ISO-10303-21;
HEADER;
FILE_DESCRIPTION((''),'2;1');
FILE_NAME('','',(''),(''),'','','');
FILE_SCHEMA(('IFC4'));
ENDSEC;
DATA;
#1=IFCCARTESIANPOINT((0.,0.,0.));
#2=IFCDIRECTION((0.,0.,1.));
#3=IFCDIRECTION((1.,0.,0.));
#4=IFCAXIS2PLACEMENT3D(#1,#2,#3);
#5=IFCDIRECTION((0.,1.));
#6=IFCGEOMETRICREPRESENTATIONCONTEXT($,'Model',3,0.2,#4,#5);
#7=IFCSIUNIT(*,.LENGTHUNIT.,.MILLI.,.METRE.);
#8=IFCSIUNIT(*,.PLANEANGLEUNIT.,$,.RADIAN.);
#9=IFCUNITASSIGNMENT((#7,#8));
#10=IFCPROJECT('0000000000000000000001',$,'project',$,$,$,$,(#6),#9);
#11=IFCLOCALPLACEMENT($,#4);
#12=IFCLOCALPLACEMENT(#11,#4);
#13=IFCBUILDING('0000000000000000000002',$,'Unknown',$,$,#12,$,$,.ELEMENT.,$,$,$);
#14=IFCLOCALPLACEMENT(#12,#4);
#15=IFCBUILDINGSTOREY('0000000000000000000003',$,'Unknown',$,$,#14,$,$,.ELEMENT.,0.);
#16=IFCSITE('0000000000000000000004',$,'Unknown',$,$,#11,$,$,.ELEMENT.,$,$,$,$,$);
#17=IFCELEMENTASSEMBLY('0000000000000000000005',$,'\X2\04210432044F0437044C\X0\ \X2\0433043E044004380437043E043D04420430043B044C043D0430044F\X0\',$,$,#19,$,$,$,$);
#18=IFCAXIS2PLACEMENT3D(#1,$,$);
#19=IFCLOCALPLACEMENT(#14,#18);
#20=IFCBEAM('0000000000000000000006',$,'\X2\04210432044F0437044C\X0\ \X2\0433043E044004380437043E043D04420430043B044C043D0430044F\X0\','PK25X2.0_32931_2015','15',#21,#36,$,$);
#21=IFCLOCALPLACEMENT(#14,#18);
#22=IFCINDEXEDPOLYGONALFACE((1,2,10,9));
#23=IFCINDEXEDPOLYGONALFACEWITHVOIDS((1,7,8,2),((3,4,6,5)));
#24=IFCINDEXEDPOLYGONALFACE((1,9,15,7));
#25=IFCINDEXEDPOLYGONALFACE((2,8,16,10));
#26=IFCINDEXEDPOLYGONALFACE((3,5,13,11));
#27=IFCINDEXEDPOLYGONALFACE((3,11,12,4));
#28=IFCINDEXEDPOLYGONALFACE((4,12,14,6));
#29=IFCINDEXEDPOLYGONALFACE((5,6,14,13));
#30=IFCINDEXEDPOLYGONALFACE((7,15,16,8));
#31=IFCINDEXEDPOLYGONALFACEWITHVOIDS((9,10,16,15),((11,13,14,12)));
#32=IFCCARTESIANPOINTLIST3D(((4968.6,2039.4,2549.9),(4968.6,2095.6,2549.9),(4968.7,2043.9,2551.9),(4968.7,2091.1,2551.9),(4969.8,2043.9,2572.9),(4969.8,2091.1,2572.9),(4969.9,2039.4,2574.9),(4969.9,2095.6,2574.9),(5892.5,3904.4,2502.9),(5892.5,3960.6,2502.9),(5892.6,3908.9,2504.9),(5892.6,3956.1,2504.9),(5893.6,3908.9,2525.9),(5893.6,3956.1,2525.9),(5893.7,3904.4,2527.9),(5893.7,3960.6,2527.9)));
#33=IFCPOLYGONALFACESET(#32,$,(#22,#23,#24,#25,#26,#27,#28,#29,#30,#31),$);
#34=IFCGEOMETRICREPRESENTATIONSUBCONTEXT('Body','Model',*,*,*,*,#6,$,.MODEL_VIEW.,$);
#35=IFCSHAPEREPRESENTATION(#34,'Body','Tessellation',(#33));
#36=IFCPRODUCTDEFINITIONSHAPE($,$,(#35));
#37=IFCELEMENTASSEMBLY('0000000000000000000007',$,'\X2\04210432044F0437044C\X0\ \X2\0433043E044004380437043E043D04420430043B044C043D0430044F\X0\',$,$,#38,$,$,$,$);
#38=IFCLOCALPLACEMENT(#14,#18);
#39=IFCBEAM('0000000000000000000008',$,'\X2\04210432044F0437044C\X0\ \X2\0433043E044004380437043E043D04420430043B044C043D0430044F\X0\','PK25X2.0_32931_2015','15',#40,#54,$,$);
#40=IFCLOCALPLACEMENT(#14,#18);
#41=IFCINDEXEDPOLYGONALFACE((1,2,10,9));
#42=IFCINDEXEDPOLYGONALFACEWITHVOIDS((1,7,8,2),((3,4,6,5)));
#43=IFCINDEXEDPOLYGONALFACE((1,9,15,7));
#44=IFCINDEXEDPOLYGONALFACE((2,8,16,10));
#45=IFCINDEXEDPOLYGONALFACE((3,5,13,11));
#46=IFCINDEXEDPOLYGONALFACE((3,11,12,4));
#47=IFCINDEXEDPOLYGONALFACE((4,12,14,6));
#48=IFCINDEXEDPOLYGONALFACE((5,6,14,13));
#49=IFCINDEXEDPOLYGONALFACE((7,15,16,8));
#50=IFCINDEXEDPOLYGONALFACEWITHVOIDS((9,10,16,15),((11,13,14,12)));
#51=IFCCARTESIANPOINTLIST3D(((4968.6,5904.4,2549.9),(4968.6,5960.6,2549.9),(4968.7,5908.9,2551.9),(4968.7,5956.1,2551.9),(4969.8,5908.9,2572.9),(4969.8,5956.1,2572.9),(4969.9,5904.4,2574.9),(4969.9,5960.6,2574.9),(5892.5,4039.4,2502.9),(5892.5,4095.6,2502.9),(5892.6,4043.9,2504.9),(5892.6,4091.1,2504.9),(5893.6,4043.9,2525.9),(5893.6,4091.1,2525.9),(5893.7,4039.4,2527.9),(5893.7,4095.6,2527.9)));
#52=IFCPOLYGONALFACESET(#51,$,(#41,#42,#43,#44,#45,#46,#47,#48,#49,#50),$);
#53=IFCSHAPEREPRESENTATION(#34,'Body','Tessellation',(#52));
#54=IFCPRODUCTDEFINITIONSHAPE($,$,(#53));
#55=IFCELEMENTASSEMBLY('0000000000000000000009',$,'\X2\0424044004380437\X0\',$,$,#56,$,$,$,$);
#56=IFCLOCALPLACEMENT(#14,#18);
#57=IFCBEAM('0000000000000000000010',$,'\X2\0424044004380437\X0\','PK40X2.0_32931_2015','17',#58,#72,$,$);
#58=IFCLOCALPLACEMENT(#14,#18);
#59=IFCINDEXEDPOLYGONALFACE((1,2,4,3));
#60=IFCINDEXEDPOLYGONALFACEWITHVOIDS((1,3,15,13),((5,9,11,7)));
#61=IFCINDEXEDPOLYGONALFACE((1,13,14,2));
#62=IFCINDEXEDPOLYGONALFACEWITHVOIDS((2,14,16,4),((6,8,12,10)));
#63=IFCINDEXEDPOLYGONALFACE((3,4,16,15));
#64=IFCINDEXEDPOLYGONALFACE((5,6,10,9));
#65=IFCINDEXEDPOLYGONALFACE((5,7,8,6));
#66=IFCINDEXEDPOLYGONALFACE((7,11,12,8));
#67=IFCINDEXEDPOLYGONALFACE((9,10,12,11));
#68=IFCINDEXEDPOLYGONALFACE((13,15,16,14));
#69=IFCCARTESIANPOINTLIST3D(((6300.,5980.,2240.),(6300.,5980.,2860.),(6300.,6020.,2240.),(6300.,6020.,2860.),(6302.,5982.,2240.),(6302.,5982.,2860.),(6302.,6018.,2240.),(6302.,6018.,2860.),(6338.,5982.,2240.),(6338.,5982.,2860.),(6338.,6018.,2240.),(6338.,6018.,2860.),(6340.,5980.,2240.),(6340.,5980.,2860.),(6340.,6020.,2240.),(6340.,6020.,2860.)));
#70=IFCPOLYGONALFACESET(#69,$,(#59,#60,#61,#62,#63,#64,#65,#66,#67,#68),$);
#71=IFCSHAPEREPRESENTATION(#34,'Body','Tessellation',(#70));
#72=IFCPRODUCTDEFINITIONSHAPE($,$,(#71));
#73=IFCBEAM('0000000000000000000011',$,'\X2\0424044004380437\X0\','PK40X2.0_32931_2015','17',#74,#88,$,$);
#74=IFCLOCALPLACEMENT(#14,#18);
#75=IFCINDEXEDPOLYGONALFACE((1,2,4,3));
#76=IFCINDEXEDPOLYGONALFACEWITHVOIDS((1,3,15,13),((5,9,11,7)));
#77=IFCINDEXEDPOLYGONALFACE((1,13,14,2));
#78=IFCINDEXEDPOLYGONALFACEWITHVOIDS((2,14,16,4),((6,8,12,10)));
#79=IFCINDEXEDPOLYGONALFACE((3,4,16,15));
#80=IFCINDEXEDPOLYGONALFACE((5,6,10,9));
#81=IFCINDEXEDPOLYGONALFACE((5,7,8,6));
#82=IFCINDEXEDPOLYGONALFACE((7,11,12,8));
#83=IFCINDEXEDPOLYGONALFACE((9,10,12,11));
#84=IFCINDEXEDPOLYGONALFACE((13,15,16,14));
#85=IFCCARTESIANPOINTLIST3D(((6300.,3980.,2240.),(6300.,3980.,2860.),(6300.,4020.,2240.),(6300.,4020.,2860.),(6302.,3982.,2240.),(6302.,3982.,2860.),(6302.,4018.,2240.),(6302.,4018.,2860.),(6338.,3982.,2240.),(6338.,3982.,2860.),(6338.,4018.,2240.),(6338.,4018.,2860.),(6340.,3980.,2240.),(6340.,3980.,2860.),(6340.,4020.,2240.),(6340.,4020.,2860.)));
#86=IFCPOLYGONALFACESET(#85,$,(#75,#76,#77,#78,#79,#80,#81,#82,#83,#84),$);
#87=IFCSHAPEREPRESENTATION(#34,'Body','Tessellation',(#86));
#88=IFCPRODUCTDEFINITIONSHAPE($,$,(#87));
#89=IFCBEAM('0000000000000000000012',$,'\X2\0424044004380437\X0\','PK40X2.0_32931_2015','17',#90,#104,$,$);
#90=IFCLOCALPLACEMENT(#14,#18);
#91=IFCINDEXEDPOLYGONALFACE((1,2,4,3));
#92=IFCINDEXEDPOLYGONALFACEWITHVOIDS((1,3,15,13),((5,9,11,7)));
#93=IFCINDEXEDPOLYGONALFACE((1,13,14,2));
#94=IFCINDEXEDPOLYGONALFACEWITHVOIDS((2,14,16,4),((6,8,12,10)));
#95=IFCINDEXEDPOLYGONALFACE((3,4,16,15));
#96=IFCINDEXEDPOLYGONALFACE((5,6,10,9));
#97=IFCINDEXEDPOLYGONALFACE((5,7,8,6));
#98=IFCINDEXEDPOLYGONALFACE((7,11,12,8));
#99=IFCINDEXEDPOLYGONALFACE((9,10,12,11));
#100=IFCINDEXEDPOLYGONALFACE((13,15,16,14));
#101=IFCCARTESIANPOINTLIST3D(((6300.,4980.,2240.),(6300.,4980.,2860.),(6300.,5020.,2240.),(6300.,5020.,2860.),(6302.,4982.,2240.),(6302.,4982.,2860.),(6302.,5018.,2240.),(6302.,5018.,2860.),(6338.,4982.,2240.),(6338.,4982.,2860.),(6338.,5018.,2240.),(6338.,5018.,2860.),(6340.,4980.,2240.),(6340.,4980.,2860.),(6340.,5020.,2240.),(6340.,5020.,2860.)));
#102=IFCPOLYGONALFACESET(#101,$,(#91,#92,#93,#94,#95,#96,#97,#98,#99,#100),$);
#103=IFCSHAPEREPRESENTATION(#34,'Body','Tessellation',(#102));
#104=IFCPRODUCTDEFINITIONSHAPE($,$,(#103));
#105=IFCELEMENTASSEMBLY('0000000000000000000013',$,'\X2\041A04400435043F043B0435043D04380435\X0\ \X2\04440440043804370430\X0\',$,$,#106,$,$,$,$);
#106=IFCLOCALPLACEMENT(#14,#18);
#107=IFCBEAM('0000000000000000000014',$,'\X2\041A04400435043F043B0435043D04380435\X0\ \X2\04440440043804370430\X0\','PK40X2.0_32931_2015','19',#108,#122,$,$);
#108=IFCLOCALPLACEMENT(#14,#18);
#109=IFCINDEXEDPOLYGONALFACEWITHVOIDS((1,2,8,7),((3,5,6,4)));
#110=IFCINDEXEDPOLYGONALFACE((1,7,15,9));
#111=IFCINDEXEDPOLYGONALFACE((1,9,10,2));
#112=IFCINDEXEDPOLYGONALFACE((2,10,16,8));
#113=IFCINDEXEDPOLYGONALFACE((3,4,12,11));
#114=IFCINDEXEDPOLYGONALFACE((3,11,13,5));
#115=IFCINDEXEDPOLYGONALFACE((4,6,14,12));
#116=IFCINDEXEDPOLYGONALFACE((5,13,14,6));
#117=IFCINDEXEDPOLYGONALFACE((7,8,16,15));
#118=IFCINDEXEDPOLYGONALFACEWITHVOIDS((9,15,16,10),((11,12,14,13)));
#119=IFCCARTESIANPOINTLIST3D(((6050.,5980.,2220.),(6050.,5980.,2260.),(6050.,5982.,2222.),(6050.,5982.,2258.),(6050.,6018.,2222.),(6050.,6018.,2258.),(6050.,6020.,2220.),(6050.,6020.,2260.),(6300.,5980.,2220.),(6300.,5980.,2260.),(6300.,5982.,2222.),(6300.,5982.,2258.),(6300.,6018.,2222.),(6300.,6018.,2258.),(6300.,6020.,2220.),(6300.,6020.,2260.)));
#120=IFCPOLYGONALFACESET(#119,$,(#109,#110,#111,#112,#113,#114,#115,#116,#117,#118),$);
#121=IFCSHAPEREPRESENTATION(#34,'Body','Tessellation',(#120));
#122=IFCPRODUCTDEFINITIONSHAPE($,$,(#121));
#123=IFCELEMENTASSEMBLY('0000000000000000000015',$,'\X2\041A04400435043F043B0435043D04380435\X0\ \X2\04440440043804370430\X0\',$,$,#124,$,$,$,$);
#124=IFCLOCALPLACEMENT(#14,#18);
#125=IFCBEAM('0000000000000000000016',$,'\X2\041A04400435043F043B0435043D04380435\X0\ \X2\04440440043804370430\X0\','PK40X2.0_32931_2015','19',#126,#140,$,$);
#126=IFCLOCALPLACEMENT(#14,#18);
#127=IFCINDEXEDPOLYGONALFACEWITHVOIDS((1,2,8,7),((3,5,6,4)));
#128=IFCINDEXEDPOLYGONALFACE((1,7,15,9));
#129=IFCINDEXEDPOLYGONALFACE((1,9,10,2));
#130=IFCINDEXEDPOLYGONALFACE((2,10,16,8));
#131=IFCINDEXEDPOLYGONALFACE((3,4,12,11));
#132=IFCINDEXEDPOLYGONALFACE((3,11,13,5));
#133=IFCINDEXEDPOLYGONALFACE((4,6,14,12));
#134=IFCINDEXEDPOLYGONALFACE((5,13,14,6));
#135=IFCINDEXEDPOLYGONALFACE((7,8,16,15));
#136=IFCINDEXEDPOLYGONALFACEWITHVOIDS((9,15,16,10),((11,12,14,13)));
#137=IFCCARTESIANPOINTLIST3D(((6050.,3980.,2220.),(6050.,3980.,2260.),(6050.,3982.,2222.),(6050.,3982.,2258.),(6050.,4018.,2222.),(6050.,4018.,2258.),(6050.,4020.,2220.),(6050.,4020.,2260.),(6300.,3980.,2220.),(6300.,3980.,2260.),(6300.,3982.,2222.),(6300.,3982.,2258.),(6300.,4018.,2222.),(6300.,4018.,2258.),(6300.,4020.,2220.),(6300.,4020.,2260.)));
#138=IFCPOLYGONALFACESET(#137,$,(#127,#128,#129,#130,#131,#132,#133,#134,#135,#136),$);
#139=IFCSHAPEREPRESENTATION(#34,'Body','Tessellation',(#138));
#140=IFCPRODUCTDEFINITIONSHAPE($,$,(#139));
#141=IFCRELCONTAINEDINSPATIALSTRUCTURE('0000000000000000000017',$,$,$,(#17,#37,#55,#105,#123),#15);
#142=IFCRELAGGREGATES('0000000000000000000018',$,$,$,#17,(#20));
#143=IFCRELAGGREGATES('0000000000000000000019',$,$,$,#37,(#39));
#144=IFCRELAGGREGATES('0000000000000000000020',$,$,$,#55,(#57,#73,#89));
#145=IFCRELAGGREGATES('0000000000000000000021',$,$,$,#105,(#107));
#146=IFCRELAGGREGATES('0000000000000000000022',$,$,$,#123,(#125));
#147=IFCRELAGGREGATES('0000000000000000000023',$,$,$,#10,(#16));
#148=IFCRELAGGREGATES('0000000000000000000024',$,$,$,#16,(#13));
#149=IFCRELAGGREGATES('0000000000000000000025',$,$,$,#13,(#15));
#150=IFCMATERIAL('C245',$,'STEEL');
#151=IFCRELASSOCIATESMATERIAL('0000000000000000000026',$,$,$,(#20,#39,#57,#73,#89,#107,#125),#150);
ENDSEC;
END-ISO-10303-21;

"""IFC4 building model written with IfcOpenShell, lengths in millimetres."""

from ifc_helpers import new_model, si_unit, direction, frame, origin_with_axes, place, context, subcontext, project, spatial, line, indexed_curve, outline, extrude, material, element, aggregate, save


model = new_model("IFC4")

# Units and contexts
model_context = context("Model", 3, precision=0.2, world=origin_with_axes(), true_north=direction((0.0, 1.0)))
body_context = subcontext(model_context, "Body", "Model", "MODEL_VIEW")
ifc_project = project(units=[si_unit("LENGTHUNIT", "METRE", prefix="MILLI"), si_unit("PLANEANGLEUNIT", "RADIAN")], contexts=[model_context])

# Site, building, storey
site_placement = place(None, origin_with_axes())
site = spatial("IfcSite", under=ifc_project, at=site_placement, Name="Unknown", CompositionType="ELEMENT")
building_placement = place(site_placement, origin_with_axes())
building = spatial("IfcBuilding", under=site, at=building_placement, Name="Unknown", CompositionType="ELEMENT")
storey_placement = place(building_placement, origin_with_axes())
storey = spatial("IfcBuildingStorey", under=building, at=storey_placement, Name="Unknown", CompositionType="ELEMENT", Elevation=0.0)

# Shared definitions
ifc_material_1 = material(Name="C245", Category="STEEL")

# Element assemblies, beams, voiding features
assembly_1_placement = place(storey_placement, frame((5920.3, 3987.4, 2514.0), z_axis=(-0.894709, 0.444326, 0.045494), x_axis=(-0.443753, -0.895865, 0.022564)))
assembly_1 = element("IfcElementAssembly", 1, at=assembly_1_placement, inside=storey, Name="Связь горизонтальная")
beam_1_placement = place(assembly_1_placement, origin_with_axes())
beam_1 = element("IfcBeam", 2, at=beam_1_placement, material=ifc_material_1, Name="Связь горизонтальная", Description="PK25X2.0_32931_2015", ObjectType="15", context=body_context, shape_type="SolidModel", body=[
    extrude(outline(indexed_curve([(-12.5, -12.5), (12.5, -12.5), (12.5, 12.5), (-12.5, 12.5)], segments=[line(1, 2, 3, 4, 1)]), holes=[indexed_curve([(-10.5, -10.5), (-10.5, 10.5), (10.5, 10.5), (10.5, -10.5)], segments=[line(1, 2, 3, 4, 1)])]), frame((0.0, 0.0, 0.0), z_axis=(-1.0, 0.0, 0.0), x_axis=(0.0, 0.0, 1.0)), (0.0, 0.0, -1.0), 2204.4),
])
voiding_feature_1_placement = place(beam_1_placement, frame((3193.8, 12.5, -493.2), z_axis=(-0.444326, 0.0, -0.895865), x_axis=(-0.895865, 0.0, 0.444326)))
element("IfcVoidingFeature", 3, at=voiding_feature_1_placement, cuts=beam_1, Name="CUT_BEAM", ObjectType="(?)", PredefinedType="HOLE", context=body_context, shape_type="SolidModel", body=[
    extrude(outline(indexed_curve([(-25.0, -25.0), (25.0, -25.0), (25.0, 25.0), (-25.0, 25.0)], segments=[line(1, 2, 3, 4, 1)])), frame((0.0, 0.0, 0.0), z_axis=(-1.0, 0.0, 0.0), x_axis=(0.0, 0.0, 1.0)), (0.0, 0.0, -1.0), 2220.1),
])
voiding_feature_2_placement = place(beam_1_placement, frame((999.5, 12.5, -493.2), z_axis=(-0.444326, 0.0, -0.895865), x_axis=(-0.895865, 0.0, 0.444326)))
element("IfcVoidingFeature", 4, at=voiding_feature_2_placement, cuts=beam_1, Name="CUT_BEAM", ObjectType="(?)", PredefinedType="HOLE", context=body_context, shape_type="SolidModel", body=[
    extrude(outline(indexed_curve([(-25.0, -25.0), (25.0, -25.0), (25.0, 25.0), (-25.0, 25.0)], segments=[line(1, 2, 3, 4, 1)])), frame((0.0, 0.0, 0.0), z_axis=(-1.0, 0.0, 0.0), x_axis=(0.0, 0.0, 1.0)), (0.0, 0.0, -1.0), 2220.1),
])
aggregate(assembly_1, [beam_1])
assembly_2_placement = place(storey_placement, frame((5920.3, 4012.6, 2514.0), z_axis=(0.894709, 0.444326, -0.045494), x_axis=(-0.443753, 0.895865, 0.022564)))
assembly_2 = element("IfcElementAssembly", 5, at=assembly_2_placement, inside=storey, Name="Связь горизонтальная")
beam_2_placement = place(assembly_2_placement, origin_with_axes())
beam_2 = element("IfcBeam", 6, at=beam_2_placement, material=ifc_material_1, Name="Связь горизонтальная", Description="PK25X2.0_32931_2015", ObjectType="15", context=body_context, shape_type="SolidModel", body=[
    extrude(outline(indexed_curve([(-12.5, -12.5), (12.5, -12.5), (12.5, 12.5), (-12.5, 12.5)], segments=[line(1, 2, 3, 4, 1)]), holes=[indexed_curve([(-10.5, -10.5), (-10.5, 10.5), (10.5, 10.5), (10.5, -10.5)], segments=[line(1, 2, 3, 4, 1)])]), frame((0.0, 0.0, 0.0), z_axis=(-1.0, 0.0, 0.0), x_axis=(0.0, 0.0, 1.0)), (0.0, 0.0, -1.0), 2204.4),
])
voiding_feature_3_placement = place(beam_2_placement, frame((1204.9, 12.5, -493.2), z_axis=(-0.444326, 0.0, 0.895865), x_axis=(0.895865, 0.0, 0.444326)))
element("IfcVoidingFeature", 7, at=voiding_feature_3_placement, cuts=beam_2, Name="CUT_BEAM", ObjectType="(?)", PredefinedType="HOLE", context=body_context, shape_type="SolidModel", body=[
    extrude(outline(indexed_curve([(-25.0, -25.0), (25.0, -25.0), (25.0, 25.0), (-25.0, 25.0)], segments=[line(1, 2, 3, 4, 1)])), frame((0.0, 0.0, 0.0), z_axis=(-1.0, 0.0, 0.0), x_axis=(0.0, 0.0, 1.0)), (0.0, 0.0, -1.0), 2220.1),
])
voiding_feature_4_placement = place(beam_2_placement, frame((-989.4, 12.5, -493.2), z_axis=(-0.444326, 0.0, 0.895865), x_axis=(0.895865, 0.0, 0.444326)))
element("IfcVoidingFeature", 8, at=voiding_feature_4_placement, cuts=beam_2, Name="CUT_BEAM", ObjectType="(?)", PredefinedType="HOLE", context=body_context, shape_type="SolidModel", body=[
    extrude(outline(indexed_curve([(-25.0, -25.0), (25.0, -25.0), (25.0, 25.0), (-25.0, 25.0)], segments=[line(1, 2, 3, 4, 1)])), frame((0.0, 0.0, 0.0), z_axis=(-1.0, 0.0, 0.0), x_axis=(0.0, 0.0, 1.0)), (0.0, 0.0, -1.0), 2220.1),
])
aggregate(assembly_2, [beam_2])

# Element assembly, beams
assembly_3_placement = place(storey_placement, frame((6320.0, -300.0, 2880.0), z_axis=(1.0, 0.0, 0.0), x_axis=(0.0, 1.0, 0.0)))
assembly_3 = element("IfcElementAssembly", 9, at=assembly_3_placement, inside=storey, Name="Фриз")
beam_3_placement = place(assembly_3_placement, frame((6300.0, -20.0, 0.0), z_axis=(1.0, 0.0, 0.0), x_axis=(0.0, -1.0, 0.0)))
beam_3 = element("IfcBeam", 10, at=beam_3_placement, material=ifc_material_1, Name="Фриз", Description="PK40X2.0_32931_2015", ObjectType="17", context=body_context, shape_type="SolidModel", body=[
    extrude(outline(indexed_curve([(-20.0, -20.0), (20.0, -20.0), (20.0, 20.0), (-20.0, 20.0)], segments=[line(1, 2, 3, 4, 1)]), holes=[indexed_curve([(-18.0, -18.0), (-18.0, 18.0), (18.0, 18.0), (18.0, -18.0)], segments=[line(1, 2, 3, 4, 1)])]), frame((0.0, 0.0, 0.0), z_axis=(-1.0, 0.0, 0.0), x_axis=(0.0, 0.0, 1.0)), (0.0, 0.0, -1.0), 620.0),
])
beam_4_placement = place(assembly_3_placement, frame((4300.0, -20.0, 0.0), z_axis=(1.0, 0.0, 0.0), x_axis=(0.0, -1.0, 0.0)))
beam_4 = element("IfcBeam", 11, at=beam_4_placement, material=ifc_material_1, Name="Фриз", Description="PK40X2.0_32931_2015", ObjectType="17", context=body_context, shape_type="SolidModel", body=[
    extrude(outline(indexed_curve([(-20.0, -20.0), (20.0, -20.0), (20.0, 20.0), (-20.0, 20.0)], segments=[line(1, 2, 3, 4, 1)]), holes=[indexed_curve([(-18.0, -18.0), (-18.0, 18.0), (18.0, 18.0), (18.0, -18.0)], segments=[line(1, 2, 3, 4, 1)])]), frame((0.0, 0.0, 0.0), z_axis=(-1.0, 0.0, 0.0), x_axis=(0.0, 0.0, 1.0)), (0.0, 0.0, -1.0), 620.0),
])
beam_5_placement = place(assembly_3_placement, frame((5300.0, -20.0, 0.0), z_axis=(1.0, 0.0, 0.0), x_axis=(0.0, -1.0, 0.0)))
beam_5 = element("IfcBeam", 12, at=beam_5_placement, material=ifc_material_1, Name="Фриз", Description="PK40X2.0_32931_2015", ObjectType="17", context=body_context, shape_type="SolidModel", body=[
    extrude(outline(indexed_curve([(-20.0, -20.0), (20.0, -20.0), (20.0, 20.0), (-20.0, 20.0)], segments=[line(1, 2, 3, 4, 1)]), holes=[indexed_curve([(-18.0, -18.0), (-18.0, 18.0), (18.0, 18.0), (18.0, -18.0)], segments=[line(1, 2, 3, 4, 1)])]), frame((0.0, 0.0, 0.0), z_axis=(-1.0, 0.0, 0.0), x_axis=(0.0, 0.0, 1.0)), (0.0, 0.0, -1.0), 620.0),
])
aggregate(assembly_3, [beam_3, beam_4, beam_5])

# Element assemblies, beams
assembly_4_placement = place(storey_placement, frame((6300.0, 6000.0, 2240.0), z_axis=(0.0, -1.0, 0.0), x_axis=(-1.0, 0.0, 0.0)))
assembly_4 = element("IfcElementAssembly", 13, at=assembly_4_placement, inside=storey, Name="Крепление фриза")
beam_6_placement = place(assembly_4_placement, origin_with_axes())
beam_6 = element("IfcBeam", 14, at=beam_6_placement, material=ifc_material_1, Name="Крепление фриза", Description="PK40X2.0_32931_2015", ObjectType="19", context=body_context, shape_type="SolidModel", body=[
    extrude(outline(indexed_curve([(-20.0, -20.0), (20.0, -20.0), (20.0, 20.0), (-20.0, 20.0)], segments=[line(1, 2, 3, 4, 1)]), holes=[indexed_curve([(-18.0, -18.0), (-18.0, 18.0), (18.0, 18.0), (18.0, -18.0)], segments=[line(1, 2, 3, 4, 1)])]), frame((0.0, 0.0, 0.0), z_axis=(-1.0, 0.0, 0.0), x_axis=(0.0, 0.0, 1.0)), (0.0, 0.0, -1.0), 250.0),
])
aggregate(assembly_4, [beam_6])
assembly_5_placement = place(storey_placement, frame((6300.0, 4000.0, 2240.0), z_axis=(0.0, -1.0, 0.0), x_axis=(-1.0, 0.0, 0.0)))
assembly_5 = element("IfcElementAssembly", 15, at=assembly_5_placement, inside=storey, Name="Крепление фриза")
beam_7_placement = place(assembly_5_placement, origin_with_axes())
beam_7 = element("IfcBeam", 16, at=beam_7_placement, material=ifc_material_1, Name="Крепление фриза", Description="PK40X2.0_32931_2015", ObjectType="19", context=body_context, shape_type="SolidModel", body=[
    extrude(outline(indexed_curve([(-20.0, -20.0), (20.0, -20.0), (20.0, 20.0), (-20.0, 20.0)], segments=[line(1, 2, 3, 4, 1)]), holes=[indexed_curve([(-18.0, -18.0), (-18.0, 18.0), (18.0, 18.0), (18.0, -18.0)], segments=[line(1, 2, 3, 4, 1)])]), frame((0.0, 0.0, 0.0), z_axis=(-1.0, 0.0, 0.0), x_axis=(0.0, 0.0, 1.0)), (0.0, 0.0, -1.0), 250.0),
])
aggregate(assembly_5, [beam_7])

save(model, "model.ifc")
